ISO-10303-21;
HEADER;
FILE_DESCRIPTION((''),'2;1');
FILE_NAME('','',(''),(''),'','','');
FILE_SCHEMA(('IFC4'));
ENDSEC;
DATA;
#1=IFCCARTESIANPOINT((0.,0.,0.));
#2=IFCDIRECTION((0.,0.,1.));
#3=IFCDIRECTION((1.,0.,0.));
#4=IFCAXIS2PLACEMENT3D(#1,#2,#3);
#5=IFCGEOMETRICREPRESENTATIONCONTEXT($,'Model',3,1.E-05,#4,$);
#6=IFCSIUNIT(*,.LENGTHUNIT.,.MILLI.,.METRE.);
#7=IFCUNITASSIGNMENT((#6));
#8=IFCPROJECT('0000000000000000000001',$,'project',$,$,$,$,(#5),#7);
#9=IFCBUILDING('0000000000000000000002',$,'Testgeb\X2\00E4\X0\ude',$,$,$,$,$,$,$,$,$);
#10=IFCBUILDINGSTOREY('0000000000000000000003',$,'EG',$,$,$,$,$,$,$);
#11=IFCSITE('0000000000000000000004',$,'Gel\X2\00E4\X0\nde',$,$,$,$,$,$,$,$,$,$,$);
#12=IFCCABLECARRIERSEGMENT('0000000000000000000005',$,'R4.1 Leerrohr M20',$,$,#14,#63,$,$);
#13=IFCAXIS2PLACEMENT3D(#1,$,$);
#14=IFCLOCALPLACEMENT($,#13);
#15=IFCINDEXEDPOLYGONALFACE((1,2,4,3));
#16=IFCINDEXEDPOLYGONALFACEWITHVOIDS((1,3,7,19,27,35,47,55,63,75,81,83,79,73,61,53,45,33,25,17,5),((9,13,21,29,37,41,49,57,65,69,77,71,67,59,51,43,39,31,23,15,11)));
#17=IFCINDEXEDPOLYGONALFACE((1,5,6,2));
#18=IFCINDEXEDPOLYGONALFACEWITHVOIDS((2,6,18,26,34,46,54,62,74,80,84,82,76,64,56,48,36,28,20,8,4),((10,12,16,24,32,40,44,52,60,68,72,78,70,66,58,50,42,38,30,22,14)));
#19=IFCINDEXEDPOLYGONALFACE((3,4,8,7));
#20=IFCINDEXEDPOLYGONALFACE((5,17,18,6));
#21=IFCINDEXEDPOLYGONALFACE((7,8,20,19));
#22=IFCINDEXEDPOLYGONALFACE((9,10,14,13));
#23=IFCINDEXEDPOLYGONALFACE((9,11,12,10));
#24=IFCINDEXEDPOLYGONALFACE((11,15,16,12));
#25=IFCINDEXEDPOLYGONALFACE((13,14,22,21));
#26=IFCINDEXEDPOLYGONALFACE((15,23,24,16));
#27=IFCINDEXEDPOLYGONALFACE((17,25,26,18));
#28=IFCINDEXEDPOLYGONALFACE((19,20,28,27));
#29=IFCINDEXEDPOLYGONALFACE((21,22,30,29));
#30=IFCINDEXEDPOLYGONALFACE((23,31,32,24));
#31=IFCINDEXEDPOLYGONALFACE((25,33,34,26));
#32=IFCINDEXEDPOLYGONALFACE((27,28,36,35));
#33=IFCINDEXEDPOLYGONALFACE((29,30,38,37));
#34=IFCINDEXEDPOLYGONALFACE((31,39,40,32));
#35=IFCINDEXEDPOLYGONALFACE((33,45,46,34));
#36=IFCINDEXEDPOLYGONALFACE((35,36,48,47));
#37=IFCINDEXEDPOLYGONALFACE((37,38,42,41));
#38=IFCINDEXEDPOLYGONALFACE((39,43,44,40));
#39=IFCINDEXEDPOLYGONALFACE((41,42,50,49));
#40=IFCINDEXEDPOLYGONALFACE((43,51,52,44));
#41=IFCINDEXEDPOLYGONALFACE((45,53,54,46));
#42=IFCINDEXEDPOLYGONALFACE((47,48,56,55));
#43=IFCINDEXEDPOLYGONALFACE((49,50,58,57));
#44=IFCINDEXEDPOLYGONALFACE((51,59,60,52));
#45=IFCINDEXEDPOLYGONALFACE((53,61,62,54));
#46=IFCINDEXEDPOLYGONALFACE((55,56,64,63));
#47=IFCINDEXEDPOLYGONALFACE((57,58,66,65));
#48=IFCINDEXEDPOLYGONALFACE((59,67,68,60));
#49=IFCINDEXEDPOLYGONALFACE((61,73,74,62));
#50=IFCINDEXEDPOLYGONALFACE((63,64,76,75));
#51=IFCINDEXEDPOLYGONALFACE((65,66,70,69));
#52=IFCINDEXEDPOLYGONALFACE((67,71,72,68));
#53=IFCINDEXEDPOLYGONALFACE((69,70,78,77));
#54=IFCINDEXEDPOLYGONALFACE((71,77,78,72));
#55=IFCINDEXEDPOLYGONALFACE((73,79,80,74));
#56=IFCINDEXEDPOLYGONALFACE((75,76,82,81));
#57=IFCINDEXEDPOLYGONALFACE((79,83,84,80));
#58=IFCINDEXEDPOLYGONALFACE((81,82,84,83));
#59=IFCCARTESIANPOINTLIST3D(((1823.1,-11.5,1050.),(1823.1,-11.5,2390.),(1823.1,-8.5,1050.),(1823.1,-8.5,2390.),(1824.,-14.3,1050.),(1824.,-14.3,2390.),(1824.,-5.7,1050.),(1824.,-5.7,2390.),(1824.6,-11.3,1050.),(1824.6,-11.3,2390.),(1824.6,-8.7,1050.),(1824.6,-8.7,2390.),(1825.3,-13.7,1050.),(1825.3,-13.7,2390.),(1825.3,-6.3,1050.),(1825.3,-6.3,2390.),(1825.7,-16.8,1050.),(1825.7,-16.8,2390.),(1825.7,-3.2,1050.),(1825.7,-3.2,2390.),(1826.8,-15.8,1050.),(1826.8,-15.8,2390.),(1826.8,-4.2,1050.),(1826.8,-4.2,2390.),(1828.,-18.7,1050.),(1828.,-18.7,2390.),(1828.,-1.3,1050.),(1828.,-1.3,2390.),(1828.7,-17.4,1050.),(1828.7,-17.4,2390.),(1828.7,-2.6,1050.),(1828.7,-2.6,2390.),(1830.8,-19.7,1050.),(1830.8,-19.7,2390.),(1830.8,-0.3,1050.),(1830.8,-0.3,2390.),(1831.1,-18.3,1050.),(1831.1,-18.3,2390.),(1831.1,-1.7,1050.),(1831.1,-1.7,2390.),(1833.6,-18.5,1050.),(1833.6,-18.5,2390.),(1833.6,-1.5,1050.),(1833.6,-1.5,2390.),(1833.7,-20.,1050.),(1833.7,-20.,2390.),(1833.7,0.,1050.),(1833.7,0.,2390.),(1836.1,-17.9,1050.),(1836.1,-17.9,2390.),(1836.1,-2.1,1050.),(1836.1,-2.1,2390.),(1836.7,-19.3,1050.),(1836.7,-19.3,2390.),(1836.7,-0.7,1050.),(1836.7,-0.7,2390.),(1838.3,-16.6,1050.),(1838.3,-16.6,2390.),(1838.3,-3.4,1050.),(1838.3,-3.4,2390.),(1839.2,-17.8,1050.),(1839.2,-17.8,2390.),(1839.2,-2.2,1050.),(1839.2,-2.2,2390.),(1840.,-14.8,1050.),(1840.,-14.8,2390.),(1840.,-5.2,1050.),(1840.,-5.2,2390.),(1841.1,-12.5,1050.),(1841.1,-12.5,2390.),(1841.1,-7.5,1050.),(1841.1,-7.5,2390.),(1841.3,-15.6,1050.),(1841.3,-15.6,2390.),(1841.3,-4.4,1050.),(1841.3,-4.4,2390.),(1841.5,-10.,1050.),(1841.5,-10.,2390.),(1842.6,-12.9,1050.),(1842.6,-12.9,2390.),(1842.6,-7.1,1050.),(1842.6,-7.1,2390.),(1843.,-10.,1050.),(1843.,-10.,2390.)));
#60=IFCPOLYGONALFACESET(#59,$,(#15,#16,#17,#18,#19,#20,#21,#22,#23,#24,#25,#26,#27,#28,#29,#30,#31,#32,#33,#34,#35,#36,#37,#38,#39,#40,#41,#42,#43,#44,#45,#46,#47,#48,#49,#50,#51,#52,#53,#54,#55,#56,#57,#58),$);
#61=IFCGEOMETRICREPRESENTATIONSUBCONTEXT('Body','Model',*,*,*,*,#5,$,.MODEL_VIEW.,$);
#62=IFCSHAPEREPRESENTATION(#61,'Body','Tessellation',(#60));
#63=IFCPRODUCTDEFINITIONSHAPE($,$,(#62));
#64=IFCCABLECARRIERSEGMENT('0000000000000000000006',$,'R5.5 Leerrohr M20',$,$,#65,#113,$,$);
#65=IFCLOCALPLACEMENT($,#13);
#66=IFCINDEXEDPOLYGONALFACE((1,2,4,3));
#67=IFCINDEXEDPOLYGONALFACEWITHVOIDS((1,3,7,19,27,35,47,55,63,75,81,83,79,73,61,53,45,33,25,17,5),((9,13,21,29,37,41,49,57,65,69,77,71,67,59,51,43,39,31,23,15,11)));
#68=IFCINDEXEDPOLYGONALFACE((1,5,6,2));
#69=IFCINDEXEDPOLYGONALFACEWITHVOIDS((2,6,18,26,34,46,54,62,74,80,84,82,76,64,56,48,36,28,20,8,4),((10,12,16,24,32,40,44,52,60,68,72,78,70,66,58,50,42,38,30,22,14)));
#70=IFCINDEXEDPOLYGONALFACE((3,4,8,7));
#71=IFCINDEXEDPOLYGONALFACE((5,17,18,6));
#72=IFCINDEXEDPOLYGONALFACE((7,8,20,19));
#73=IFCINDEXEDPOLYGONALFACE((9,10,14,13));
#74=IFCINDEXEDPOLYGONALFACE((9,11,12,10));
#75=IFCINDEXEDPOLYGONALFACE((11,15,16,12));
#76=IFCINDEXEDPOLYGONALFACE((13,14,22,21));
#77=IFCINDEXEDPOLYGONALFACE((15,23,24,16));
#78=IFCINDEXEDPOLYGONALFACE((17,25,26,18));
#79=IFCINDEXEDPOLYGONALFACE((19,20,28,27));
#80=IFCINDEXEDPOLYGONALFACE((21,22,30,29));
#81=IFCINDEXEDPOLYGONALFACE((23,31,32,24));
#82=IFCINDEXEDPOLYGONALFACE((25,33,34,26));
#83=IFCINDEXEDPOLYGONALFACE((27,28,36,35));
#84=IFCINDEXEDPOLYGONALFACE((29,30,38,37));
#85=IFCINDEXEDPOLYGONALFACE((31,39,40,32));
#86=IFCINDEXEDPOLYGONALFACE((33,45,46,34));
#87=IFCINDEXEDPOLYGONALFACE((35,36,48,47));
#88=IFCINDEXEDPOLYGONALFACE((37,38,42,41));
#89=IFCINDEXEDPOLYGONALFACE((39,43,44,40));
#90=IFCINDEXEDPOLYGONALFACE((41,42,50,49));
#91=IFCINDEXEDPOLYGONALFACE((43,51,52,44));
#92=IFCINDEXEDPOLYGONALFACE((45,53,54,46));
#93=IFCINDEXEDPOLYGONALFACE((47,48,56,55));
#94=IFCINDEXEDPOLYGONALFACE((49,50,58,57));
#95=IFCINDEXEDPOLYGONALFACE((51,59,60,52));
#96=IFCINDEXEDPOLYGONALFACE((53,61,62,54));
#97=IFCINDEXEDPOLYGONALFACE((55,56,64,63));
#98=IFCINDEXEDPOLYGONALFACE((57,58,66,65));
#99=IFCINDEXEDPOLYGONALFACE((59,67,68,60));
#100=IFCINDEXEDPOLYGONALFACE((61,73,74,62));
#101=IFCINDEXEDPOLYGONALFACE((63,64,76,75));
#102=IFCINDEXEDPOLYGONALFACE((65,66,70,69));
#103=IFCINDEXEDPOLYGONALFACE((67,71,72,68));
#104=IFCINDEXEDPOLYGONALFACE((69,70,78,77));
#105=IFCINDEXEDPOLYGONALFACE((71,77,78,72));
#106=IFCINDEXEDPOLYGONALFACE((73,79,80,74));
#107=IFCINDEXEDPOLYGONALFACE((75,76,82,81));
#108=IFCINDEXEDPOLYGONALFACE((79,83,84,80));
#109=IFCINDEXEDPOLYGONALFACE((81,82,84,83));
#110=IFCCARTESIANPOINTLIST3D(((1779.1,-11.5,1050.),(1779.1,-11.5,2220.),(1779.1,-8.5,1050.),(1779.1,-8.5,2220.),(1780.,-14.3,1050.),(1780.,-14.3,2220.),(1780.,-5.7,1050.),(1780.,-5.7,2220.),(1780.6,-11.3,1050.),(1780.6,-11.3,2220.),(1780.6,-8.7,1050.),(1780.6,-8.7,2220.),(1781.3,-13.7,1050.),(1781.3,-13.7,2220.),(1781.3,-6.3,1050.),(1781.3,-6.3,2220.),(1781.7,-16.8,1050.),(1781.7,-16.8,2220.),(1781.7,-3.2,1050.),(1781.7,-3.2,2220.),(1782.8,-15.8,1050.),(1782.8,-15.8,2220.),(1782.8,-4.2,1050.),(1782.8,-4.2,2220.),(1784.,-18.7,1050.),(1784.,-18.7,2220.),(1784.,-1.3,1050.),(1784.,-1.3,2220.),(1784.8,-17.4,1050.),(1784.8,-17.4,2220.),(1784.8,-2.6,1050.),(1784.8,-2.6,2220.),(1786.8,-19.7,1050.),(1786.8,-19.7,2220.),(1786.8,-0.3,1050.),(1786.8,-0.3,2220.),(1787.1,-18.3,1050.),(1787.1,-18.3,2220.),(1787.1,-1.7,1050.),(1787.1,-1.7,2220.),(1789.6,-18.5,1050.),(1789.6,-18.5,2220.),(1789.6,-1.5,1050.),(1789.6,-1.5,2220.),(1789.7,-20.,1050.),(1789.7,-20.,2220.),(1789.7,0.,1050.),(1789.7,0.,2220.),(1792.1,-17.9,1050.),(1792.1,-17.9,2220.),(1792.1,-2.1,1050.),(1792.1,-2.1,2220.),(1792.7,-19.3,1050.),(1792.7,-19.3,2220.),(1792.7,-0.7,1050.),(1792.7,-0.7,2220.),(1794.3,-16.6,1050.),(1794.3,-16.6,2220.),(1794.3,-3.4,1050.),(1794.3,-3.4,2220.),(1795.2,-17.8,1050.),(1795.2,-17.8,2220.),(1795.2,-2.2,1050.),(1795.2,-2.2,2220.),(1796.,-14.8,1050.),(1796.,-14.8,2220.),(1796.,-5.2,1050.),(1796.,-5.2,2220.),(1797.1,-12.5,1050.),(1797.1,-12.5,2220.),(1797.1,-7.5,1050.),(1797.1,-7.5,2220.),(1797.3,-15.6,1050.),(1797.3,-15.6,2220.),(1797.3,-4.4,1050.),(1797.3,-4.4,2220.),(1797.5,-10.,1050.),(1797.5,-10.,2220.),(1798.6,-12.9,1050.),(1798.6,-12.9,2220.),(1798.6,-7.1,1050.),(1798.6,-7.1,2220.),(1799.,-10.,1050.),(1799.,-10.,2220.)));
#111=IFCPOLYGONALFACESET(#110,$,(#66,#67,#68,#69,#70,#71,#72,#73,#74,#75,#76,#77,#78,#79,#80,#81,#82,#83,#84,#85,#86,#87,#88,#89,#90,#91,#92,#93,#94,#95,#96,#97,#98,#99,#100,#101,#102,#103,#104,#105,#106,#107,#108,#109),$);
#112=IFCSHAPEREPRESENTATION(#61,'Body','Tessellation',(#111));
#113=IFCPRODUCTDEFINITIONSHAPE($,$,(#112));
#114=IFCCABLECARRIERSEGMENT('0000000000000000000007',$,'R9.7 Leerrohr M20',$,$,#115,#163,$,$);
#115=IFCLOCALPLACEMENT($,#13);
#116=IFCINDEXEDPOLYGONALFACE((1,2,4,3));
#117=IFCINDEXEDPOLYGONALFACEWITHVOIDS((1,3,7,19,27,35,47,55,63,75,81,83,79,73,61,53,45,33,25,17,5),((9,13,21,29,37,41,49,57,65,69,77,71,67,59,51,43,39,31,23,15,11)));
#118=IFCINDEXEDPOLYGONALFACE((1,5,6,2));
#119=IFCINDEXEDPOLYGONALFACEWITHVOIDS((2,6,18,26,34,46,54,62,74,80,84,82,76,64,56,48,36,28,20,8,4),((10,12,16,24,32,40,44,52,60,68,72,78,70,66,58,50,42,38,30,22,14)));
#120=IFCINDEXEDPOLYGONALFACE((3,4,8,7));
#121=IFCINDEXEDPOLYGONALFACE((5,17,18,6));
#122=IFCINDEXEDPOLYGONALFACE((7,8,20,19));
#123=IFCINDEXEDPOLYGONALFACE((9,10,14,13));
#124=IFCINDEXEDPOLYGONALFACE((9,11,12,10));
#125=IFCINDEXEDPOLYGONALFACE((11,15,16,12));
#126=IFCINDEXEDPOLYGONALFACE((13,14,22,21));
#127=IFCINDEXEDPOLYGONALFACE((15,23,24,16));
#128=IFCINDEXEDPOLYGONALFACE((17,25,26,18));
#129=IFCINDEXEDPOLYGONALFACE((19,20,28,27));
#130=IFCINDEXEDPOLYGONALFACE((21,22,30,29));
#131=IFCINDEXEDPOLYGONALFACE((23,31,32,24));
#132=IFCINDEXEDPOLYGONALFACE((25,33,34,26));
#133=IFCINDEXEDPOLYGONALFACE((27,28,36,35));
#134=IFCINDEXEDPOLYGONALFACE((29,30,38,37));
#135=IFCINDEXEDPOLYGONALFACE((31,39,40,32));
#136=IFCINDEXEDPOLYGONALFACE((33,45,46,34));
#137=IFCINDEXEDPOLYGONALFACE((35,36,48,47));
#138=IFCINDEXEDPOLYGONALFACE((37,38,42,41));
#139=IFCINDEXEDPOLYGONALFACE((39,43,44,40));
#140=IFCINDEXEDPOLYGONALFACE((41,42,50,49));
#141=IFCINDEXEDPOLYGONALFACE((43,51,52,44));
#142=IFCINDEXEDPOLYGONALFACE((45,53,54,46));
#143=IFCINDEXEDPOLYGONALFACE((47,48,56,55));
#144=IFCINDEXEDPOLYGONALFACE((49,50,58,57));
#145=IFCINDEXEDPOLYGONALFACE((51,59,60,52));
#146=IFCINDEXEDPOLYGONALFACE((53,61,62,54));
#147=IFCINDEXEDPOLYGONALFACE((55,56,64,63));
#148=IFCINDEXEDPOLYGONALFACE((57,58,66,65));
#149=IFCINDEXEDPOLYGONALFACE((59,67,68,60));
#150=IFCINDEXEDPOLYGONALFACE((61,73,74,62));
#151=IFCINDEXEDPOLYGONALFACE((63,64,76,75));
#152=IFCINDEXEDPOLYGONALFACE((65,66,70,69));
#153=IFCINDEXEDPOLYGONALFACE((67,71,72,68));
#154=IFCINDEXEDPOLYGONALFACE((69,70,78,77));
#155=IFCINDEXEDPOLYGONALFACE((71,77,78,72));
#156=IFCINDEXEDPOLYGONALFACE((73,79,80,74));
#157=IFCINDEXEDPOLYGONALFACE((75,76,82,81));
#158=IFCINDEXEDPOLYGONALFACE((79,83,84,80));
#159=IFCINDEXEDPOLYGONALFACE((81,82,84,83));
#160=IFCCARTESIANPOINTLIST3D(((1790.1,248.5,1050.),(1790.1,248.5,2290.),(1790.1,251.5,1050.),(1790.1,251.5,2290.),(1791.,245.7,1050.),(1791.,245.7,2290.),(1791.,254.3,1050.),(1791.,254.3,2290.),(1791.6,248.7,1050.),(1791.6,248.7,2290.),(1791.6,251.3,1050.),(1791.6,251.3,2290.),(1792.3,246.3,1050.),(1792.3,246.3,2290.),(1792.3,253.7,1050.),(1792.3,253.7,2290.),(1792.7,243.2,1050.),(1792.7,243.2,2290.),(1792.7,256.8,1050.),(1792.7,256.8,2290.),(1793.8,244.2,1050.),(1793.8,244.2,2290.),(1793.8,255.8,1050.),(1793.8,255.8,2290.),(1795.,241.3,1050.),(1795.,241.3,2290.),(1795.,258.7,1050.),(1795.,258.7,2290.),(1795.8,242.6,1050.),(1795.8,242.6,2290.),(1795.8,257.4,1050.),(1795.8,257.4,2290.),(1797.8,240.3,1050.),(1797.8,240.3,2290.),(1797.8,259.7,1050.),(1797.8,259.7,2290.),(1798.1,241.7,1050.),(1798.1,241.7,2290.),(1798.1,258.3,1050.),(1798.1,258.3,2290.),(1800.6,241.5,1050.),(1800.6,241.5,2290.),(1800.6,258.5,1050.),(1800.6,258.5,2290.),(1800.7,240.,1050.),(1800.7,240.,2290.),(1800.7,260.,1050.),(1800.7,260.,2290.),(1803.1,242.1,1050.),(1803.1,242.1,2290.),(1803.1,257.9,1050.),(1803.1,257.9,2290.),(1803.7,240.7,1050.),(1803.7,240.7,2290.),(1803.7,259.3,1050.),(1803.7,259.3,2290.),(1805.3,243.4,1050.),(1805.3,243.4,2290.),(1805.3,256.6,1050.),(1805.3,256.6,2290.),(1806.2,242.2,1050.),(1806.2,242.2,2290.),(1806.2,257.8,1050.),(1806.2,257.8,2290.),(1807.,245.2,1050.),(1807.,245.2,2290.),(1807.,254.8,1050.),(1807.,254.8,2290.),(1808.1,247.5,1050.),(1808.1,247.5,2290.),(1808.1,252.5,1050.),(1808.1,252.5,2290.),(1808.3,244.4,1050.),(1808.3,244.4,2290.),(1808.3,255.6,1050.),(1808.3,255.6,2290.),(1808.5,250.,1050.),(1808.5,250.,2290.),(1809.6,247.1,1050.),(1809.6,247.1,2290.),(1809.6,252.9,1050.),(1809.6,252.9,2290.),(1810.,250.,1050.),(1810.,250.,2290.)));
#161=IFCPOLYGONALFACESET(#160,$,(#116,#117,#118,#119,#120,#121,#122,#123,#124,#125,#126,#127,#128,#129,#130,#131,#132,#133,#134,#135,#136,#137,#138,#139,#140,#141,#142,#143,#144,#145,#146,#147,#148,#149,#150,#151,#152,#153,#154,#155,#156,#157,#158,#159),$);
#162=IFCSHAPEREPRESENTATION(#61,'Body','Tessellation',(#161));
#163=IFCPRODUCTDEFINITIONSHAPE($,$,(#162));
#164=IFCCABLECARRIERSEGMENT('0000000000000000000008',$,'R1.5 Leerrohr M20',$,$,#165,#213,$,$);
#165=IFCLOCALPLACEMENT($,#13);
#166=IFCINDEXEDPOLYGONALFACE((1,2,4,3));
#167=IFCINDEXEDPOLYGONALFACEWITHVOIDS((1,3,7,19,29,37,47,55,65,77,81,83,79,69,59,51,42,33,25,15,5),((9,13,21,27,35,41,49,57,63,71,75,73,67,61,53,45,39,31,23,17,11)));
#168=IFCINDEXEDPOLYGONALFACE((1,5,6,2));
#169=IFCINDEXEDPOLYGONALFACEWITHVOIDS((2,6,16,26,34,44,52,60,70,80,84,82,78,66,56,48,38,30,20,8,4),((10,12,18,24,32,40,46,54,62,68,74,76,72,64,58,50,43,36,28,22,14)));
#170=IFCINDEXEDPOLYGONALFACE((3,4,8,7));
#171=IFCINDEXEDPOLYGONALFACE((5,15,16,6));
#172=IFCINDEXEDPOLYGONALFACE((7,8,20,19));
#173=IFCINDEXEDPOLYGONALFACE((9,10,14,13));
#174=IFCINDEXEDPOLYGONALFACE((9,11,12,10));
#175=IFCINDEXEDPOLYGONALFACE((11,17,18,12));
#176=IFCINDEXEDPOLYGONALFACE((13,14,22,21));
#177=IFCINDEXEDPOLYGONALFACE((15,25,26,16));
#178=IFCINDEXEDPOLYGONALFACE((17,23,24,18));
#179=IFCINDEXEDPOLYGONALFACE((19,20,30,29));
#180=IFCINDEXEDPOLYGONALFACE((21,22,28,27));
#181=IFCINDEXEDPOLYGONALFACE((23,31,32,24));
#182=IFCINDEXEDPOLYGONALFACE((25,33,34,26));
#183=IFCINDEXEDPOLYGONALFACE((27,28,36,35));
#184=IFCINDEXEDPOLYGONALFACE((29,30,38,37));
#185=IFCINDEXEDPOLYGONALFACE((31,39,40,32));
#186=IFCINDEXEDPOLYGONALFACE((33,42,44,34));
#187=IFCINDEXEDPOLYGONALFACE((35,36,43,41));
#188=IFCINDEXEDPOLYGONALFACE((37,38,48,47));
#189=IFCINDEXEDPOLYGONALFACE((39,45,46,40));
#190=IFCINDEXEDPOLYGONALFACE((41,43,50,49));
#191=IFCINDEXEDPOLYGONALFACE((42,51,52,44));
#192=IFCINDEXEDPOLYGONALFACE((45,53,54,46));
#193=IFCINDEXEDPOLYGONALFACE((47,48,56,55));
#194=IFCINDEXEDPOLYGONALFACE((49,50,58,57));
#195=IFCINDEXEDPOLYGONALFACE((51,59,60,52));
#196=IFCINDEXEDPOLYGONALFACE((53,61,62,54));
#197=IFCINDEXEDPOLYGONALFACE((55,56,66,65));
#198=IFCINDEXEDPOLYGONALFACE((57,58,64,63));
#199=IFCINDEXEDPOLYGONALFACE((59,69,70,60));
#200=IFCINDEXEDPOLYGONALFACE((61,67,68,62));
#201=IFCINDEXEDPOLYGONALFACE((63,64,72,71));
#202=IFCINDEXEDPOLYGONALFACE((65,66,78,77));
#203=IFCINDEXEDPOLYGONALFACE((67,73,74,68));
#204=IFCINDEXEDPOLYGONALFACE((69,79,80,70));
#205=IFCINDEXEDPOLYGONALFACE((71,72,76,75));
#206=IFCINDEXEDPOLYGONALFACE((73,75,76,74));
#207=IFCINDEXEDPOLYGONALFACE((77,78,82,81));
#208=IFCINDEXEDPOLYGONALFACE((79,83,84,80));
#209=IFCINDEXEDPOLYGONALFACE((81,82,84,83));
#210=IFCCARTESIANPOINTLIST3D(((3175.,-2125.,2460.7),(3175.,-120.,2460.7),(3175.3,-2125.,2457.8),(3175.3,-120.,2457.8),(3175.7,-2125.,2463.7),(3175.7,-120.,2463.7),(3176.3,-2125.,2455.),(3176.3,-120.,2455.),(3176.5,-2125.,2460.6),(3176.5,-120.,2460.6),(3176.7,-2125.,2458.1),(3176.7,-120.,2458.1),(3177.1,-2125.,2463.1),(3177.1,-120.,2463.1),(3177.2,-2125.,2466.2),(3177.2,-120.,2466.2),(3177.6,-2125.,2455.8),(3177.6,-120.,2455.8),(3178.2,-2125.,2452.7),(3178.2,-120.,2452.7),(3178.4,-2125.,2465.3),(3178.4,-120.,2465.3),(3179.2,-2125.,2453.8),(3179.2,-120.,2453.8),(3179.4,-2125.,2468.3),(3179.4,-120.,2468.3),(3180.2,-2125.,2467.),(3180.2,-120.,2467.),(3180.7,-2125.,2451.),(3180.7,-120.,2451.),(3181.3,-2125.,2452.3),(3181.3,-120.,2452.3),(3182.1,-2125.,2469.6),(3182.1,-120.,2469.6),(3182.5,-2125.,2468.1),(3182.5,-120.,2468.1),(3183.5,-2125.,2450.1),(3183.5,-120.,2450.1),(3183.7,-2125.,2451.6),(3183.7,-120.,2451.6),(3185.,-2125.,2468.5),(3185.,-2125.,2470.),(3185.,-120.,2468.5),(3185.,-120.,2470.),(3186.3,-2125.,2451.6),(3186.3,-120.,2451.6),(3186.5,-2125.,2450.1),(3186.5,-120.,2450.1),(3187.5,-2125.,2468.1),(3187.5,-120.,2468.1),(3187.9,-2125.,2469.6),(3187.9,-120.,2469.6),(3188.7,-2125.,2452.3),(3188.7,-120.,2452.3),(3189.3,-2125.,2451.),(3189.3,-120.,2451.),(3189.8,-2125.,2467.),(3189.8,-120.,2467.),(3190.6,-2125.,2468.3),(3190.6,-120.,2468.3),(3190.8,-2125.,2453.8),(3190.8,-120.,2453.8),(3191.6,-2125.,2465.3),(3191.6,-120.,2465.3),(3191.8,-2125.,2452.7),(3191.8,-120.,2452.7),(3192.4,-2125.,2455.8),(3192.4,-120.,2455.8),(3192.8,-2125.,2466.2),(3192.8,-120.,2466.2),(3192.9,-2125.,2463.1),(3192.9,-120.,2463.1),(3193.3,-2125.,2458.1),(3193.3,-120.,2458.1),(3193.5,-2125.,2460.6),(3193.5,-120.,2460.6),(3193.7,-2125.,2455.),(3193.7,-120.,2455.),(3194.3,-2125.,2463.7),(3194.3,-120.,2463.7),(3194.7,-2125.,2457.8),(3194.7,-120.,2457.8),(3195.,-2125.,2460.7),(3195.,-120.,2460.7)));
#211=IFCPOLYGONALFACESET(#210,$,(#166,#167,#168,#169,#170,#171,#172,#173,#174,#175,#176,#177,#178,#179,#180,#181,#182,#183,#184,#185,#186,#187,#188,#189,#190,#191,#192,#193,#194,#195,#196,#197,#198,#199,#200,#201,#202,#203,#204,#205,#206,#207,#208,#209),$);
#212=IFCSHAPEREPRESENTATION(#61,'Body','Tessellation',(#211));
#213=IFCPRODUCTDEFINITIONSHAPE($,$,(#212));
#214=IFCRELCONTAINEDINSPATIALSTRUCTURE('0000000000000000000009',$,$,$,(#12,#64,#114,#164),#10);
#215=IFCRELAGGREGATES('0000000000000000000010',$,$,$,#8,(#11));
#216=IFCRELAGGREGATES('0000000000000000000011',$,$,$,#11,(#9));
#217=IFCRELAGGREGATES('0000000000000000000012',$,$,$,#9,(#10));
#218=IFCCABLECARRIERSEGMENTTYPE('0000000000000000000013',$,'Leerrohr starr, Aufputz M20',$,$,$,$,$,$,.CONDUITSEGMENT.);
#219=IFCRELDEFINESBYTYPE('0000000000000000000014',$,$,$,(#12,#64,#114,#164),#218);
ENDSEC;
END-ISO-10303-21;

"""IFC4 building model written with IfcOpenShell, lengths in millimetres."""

from ifc_helpers import new_model, si_unit, frame, origin_with_axes, place, context, subcontext, project, spatial, hollow_circle, extrude, type_object, element, save


model = new_model("IFC4")

# Units and contexts
model_context = context("Model", 3, precision=1e-05, world=origin_with_axes())
body_context = subcontext(model_context, "Body", "Model", "MODEL_VIEW")
ifc_project = project(units=[si_unit("LENGTHUNIT", "METRE", prefix="MILLI")], contexts=[model_context])

# Site, building, storey
site = spatial("IfcSite", under=ifc_project, Name="Gelände")
building = spatial("IfcBuilding", under=site, Name="Testgebäude")
storey = spatial("IfcBuildingStorey", under=building, Name="EG")

# Cable carrier segments
cable_carrier_segment_type_1 = type_object("IfcCableCarrierSegmentType", Name="Leerrohr starr, Aufputz M20", PredefinedType="CONDUITSEGMENT")
for number, where, z_axis, x_axis, name in (
    (1, (1833.0, -10.0, 1050.0), (0.0, 0.0, 1.0), (1.0, 0.0, 0.0), "R4.1 Leerrohr M20"),
):
    element("IfcCableCarrierSegment", number, at=place(None, frame(where, z_axis=z_axis, x_axis=x_axis)), inside=storey, type_object=cable_carrier_segment_type_1, Name=name, context=body_context, shape_type="SweptSolid", body=[
        extrude(hollow_circle(Radius=10.0, WallThickness=1.5), None, (0.0, 0.0, 1.0), 1340.0),
    ])
cable_carrier_segment_1_placement = place(None, frame((1789.0, -10.0, 2220.0), z_axis=(0.0, 0.0, -1.0), x_axis=(1.0, 0.0, 0.0)))
element("IfcCableCarrierSegment", 2, at=cable_carrier_segment_1_placement, inside=storey, type_object=cable_carrier_segment_type_1, Name="R5.5 Leerrohr M20", context=body_context, shape_type="SweptSolid", body=[
    extrude(hollow_circle(Radius=10.0, WallThickness=1.5), None, (0.0, 0.0, 1.0), 1170.0),
])
cable_carrier_segment_2_placement = place(None, frame((1800.0, 250.0, 2290.0), z_axis=(0.0, 0.0, -1.0), x_axis=(1.0, 0.0, 0.0)))
element("IfcCableCarrierSegment", 3, at=cable_carrier_segment_2_placement, inside=storey, type_object=cable_carrier_segment_type_1, Name="R9.7 Leerrohr M20", context=body_context, shape_type="SweptSolid", body=[
    extrude(hollow_circle(Radius=10.0, WallThickness=1.5), None, (0.0, 0.0, 1.0), 1240.0),
])
cable_carrier_segment_3_placement = place(None, frame((3185.0, -120.0, 2460.0), z_axis=(0.0, -1.0, 0.0), x_axis=(0.0, 0.0, 1.0)))
element("IfcCableCarrierSegment", 4, at=cable_carrier_segment_3_placement, inside=storey, type_object=cable_carrier_segment_type_1, Name="R1.5 Leerrohr M20", context=body_context, shape_type="SweptSolid", body=[
    extrude(hollow_circle(Radius=10.0, WallThickness=1.5), None, (0.0, 0.0, 1.0), 2005.0),
])

save(model, "model.ifc")
